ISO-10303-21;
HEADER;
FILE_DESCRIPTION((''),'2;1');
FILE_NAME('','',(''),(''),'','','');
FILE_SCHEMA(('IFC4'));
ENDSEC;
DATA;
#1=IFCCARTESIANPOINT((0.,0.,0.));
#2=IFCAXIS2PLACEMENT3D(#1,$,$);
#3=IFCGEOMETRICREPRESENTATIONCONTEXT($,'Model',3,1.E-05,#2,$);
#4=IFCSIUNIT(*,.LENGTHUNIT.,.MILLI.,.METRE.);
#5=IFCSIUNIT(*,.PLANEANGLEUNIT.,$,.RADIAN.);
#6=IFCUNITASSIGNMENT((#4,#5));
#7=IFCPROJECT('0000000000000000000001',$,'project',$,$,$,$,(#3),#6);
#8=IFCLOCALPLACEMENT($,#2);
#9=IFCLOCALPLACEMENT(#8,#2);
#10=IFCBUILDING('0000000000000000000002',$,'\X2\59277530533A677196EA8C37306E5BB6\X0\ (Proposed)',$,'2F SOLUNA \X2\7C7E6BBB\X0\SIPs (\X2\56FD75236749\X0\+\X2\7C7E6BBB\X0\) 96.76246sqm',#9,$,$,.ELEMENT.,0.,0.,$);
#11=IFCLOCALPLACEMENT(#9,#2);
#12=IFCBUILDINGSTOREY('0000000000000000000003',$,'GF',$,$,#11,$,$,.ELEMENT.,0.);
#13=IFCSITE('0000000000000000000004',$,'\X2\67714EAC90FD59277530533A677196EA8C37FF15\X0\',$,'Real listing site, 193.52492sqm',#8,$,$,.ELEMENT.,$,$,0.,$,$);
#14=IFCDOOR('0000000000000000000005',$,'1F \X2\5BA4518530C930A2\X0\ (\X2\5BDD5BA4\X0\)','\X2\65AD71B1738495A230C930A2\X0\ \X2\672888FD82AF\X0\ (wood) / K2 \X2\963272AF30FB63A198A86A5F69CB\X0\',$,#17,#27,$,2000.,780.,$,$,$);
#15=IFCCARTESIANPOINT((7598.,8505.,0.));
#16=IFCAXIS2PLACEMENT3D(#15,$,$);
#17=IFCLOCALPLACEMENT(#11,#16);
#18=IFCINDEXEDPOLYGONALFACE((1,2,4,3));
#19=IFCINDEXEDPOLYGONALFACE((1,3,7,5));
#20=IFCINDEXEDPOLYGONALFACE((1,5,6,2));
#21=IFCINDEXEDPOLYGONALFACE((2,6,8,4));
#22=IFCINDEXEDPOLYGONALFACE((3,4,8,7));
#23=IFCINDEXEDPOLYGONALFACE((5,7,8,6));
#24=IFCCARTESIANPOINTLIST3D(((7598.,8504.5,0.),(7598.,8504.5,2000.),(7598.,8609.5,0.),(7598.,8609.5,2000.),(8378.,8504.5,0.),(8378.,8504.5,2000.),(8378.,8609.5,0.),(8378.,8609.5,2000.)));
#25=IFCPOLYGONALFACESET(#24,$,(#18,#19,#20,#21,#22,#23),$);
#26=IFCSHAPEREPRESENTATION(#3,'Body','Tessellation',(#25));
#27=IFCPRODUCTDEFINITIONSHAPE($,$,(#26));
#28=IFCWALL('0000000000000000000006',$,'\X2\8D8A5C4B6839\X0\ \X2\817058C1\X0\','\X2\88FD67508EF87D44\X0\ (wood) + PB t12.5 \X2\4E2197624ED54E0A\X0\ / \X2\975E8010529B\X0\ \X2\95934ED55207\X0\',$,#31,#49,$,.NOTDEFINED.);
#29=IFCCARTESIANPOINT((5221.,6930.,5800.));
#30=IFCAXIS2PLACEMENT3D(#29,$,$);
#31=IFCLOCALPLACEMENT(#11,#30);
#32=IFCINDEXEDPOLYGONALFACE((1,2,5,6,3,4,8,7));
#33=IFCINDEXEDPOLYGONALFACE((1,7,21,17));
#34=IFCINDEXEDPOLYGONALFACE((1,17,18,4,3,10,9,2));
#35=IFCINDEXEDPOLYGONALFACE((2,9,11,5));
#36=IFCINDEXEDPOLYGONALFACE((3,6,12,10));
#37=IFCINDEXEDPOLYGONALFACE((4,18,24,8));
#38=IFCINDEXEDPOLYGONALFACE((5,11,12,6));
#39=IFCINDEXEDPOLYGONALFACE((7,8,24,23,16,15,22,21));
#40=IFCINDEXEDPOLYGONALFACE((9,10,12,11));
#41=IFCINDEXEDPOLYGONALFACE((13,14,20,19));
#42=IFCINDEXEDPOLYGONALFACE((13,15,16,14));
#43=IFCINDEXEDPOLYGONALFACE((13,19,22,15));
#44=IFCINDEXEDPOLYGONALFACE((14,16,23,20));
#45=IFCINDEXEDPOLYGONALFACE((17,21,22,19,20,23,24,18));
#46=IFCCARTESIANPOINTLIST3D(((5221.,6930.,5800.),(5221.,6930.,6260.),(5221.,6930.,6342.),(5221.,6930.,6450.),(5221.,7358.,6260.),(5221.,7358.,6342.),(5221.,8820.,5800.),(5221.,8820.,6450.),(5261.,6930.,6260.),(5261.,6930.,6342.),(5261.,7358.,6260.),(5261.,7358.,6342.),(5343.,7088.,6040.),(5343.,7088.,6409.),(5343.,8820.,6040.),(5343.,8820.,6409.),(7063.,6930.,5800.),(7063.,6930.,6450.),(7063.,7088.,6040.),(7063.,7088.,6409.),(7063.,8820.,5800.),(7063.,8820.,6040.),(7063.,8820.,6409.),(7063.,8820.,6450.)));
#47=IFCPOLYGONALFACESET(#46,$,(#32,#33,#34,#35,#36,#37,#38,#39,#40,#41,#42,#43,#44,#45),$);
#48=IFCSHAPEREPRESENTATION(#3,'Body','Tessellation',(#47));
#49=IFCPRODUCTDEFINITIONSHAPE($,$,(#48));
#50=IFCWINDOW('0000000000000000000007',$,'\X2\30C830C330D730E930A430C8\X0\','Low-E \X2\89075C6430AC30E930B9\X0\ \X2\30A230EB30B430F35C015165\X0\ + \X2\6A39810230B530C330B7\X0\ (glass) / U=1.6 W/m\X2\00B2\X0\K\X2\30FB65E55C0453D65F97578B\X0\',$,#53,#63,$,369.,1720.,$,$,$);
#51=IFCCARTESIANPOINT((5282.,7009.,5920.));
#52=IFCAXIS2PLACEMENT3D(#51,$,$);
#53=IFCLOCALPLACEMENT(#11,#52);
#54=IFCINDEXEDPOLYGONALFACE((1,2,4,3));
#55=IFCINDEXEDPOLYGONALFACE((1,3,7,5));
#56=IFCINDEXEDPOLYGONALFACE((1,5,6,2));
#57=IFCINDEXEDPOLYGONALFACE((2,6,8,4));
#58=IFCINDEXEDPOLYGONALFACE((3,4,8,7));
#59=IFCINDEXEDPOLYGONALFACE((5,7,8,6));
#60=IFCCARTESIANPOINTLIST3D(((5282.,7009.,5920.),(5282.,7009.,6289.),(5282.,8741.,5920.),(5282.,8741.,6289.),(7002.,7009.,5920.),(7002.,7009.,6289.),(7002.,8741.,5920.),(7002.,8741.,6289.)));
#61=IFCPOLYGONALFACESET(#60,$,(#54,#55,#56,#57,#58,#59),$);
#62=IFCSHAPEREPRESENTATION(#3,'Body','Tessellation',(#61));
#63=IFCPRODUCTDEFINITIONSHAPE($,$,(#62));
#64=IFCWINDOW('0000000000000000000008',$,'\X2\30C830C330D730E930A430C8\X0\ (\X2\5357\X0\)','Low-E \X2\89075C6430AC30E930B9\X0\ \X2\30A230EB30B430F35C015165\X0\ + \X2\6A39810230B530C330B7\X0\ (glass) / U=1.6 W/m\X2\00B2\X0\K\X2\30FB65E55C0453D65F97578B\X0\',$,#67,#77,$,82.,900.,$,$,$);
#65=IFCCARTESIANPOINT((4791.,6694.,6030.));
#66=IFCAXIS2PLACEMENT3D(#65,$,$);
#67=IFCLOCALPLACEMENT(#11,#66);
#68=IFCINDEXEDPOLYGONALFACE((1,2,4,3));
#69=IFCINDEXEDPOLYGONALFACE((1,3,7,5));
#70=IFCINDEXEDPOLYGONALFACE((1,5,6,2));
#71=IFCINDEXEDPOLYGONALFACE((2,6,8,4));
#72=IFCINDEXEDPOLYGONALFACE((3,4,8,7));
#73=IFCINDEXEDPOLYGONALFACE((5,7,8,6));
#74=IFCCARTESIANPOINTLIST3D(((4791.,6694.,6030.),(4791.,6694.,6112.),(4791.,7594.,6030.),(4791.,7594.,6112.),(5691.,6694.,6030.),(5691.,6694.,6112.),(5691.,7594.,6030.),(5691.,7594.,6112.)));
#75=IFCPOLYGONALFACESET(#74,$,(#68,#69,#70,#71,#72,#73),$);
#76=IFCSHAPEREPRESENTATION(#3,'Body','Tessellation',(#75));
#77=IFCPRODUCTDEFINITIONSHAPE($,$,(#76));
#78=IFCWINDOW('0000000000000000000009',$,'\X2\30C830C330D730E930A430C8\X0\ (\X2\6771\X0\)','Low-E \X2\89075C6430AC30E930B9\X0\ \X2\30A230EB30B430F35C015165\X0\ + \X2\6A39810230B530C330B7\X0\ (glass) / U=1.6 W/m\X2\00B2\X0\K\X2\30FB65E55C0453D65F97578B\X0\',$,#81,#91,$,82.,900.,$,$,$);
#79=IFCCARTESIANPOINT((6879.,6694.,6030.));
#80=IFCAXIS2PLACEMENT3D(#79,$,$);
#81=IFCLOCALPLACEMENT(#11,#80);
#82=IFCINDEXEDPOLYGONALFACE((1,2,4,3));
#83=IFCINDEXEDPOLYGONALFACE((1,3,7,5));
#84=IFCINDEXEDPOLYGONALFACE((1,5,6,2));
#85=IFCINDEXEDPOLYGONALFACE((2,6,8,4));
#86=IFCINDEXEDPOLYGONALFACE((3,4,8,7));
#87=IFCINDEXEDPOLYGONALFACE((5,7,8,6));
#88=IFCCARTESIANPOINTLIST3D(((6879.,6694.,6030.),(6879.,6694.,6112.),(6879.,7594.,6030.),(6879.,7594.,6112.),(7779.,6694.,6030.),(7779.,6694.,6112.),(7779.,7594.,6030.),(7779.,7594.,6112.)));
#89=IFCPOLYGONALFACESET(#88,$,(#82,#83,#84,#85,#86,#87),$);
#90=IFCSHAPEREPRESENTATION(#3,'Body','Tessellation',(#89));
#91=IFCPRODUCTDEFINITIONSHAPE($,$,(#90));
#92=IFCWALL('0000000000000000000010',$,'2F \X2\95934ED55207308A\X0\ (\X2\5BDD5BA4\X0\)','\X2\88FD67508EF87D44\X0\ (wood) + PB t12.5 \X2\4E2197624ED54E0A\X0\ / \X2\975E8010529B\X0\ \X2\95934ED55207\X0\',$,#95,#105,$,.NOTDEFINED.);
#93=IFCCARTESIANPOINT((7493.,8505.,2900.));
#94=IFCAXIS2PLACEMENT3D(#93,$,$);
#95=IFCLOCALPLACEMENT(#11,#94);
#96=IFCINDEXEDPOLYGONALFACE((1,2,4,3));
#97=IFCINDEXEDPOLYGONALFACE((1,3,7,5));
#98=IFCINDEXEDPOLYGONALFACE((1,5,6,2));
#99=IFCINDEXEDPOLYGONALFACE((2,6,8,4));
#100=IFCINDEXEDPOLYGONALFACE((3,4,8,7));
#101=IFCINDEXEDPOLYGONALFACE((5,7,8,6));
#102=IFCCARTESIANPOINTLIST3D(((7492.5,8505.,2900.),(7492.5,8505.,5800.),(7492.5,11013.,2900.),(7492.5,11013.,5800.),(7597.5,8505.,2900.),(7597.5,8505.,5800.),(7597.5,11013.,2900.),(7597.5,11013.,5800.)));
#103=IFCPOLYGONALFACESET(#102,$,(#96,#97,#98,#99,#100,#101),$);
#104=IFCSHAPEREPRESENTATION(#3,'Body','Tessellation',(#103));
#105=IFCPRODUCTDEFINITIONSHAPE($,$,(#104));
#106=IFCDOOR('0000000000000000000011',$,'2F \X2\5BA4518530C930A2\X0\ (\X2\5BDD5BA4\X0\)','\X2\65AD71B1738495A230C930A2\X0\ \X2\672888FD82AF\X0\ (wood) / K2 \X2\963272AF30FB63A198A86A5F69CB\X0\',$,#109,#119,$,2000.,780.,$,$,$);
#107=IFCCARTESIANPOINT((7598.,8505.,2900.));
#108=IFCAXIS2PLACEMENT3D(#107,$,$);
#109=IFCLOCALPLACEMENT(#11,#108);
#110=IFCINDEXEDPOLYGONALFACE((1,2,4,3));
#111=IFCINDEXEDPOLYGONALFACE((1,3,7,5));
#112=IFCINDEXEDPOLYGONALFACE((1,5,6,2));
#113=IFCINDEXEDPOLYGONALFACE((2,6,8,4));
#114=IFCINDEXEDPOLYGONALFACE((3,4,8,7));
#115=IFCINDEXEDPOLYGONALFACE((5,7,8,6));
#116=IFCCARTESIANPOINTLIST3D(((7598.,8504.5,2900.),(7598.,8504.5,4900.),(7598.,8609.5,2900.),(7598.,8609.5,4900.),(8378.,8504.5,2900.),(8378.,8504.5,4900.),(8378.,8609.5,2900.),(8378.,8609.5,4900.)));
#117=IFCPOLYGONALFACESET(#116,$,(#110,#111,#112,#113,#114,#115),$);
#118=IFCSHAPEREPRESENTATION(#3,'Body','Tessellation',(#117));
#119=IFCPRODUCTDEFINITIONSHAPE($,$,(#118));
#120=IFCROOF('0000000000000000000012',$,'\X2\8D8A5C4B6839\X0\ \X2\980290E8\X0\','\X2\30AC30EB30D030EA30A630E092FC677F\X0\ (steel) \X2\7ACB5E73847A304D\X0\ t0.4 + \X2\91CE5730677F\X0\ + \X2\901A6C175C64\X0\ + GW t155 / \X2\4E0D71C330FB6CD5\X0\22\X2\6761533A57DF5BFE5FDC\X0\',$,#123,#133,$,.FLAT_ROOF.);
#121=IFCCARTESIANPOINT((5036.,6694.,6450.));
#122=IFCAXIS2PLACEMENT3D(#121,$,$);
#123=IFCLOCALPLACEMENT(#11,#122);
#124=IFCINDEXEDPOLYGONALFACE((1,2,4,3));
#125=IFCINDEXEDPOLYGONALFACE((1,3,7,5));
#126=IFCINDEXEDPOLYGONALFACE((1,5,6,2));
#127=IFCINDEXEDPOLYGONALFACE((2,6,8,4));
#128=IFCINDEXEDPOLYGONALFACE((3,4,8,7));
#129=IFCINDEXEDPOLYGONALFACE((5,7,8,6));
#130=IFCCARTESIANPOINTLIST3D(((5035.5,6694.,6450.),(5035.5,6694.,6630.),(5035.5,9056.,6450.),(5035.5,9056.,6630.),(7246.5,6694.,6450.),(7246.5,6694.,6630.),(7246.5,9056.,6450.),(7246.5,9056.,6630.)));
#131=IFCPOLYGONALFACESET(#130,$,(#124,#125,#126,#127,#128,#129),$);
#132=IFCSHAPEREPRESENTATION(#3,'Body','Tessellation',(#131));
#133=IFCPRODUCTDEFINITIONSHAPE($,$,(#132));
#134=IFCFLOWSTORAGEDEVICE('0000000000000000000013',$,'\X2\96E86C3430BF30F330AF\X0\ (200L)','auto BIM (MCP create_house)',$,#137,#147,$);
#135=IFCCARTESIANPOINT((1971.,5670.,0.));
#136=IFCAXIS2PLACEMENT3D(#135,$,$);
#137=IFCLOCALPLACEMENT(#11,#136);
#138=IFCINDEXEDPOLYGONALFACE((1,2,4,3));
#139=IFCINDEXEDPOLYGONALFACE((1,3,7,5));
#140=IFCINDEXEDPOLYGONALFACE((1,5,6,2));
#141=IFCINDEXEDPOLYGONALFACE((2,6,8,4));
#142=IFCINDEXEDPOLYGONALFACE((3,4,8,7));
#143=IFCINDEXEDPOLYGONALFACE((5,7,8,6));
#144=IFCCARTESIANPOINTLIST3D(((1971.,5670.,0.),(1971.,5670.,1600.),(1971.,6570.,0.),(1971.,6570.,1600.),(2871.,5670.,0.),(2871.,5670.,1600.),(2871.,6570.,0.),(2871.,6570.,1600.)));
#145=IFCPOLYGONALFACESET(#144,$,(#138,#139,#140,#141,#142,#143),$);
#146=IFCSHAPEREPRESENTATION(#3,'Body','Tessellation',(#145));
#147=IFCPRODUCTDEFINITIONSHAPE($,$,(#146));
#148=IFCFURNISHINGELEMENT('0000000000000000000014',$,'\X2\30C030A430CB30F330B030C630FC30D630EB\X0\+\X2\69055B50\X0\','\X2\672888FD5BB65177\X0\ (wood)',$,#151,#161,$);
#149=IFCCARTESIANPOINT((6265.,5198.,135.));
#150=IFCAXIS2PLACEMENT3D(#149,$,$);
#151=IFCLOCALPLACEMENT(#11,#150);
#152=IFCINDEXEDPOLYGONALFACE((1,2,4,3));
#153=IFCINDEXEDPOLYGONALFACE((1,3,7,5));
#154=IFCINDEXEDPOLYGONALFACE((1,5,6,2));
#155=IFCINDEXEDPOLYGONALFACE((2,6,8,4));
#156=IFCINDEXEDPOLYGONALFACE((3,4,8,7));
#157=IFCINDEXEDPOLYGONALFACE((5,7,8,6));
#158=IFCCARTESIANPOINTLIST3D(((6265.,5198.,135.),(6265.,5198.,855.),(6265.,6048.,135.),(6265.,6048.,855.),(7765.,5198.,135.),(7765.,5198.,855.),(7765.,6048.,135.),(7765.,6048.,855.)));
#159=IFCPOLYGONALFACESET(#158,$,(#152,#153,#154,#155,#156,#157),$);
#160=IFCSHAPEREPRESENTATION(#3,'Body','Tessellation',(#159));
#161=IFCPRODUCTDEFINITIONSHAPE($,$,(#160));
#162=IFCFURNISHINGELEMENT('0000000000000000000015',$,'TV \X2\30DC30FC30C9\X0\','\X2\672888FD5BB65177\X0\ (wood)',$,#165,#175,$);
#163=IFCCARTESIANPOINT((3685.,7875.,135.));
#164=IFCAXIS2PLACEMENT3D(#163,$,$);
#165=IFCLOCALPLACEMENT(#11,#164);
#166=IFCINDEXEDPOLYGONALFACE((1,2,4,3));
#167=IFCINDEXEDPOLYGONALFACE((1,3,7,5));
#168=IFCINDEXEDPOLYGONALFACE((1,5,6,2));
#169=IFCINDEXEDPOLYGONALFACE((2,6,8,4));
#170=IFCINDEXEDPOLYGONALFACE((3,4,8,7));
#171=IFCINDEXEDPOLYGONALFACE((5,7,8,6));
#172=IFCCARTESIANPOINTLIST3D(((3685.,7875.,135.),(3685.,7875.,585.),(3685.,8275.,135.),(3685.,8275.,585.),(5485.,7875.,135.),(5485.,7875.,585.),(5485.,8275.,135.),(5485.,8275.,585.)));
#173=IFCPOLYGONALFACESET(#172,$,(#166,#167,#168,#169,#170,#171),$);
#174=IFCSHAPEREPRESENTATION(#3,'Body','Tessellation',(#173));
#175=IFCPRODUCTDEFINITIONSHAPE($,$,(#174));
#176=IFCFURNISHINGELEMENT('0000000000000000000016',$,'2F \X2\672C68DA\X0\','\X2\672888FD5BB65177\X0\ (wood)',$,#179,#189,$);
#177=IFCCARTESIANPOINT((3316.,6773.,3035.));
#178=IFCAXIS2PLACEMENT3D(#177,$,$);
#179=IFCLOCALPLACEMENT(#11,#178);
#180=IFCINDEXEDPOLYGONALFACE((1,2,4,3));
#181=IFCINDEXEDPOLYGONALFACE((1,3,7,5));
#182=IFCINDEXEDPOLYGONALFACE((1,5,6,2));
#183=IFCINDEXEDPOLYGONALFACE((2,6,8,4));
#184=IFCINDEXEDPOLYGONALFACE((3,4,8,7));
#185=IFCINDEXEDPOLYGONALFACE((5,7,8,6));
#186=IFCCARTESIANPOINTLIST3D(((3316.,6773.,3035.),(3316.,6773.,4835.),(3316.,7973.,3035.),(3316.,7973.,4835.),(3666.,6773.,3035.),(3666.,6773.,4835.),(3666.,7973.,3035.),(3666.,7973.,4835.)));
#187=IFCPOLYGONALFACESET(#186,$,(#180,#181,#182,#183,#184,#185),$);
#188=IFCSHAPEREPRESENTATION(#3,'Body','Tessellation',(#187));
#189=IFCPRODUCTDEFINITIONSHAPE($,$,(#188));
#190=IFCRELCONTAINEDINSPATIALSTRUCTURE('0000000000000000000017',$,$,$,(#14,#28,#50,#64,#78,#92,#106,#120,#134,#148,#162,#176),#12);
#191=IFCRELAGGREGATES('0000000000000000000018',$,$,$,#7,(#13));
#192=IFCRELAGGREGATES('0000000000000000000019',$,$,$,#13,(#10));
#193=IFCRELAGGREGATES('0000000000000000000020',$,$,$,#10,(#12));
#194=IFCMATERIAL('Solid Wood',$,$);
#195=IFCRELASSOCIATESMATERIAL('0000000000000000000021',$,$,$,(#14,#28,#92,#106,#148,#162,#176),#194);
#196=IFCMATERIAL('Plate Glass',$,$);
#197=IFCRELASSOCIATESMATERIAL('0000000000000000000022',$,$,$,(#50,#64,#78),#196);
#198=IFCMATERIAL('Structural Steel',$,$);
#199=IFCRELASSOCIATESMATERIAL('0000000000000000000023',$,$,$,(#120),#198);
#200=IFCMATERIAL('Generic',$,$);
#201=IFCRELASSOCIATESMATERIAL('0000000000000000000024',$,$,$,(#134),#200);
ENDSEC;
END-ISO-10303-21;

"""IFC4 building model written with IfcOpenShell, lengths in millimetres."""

from ifc_helpers import new_model, si_unit, frame, frame_2d, origin, place, context, project, spatial, rectangle, extrude, material, element, fill, save


model = new_model("IFC4")

# Units and contexts
model_context = context("Model", 3, precision=1e-05, world=origin())
ifc_project = project(units=[si_unit("LENGTHUNIT", "METRE", prefix="MILLI"), si_unit("PLANEANGLEUNIT", "RADIAN")], contexts=[model_context])

# Site, building, storey
site_placement = place(None, origin())
site = spatial("IfcSite", under=ifc_project, at=site_placement, Name="東京都大田区東雪谷５", ObjectType="Real listing site, 193.52492sqm", CompositionType="ELEMENT", RefElevation=0.0)
building_placement = place(site_placement, origin())
building = spatial("IfcBuilding", under=site, at=building_placement, Name="大田区東雪谷の家 (Proposed)", ObjectType="2F SOLUNA 籾殻SIPs (国産杉+籾殻) 96.76246sqm", CompositionType="ELEMENT", ElevationOfRefHeight=0.0, ElevationOfTerrain=0.0)
storey_placement = place(building_placement, origin())
storey = spatial("IfcBuildingStorey", under=building, at=storey_placement, Name="GF", CompositionType="ELEMENT", Elevation=0.0)

# Shared definitions
ifc_material_1 = material(Name="Solid Wood")

# Door
door_1_placement = place(storey_placement, frame((7598.0, 8505.0, 0.0)))
element("IfcDoor", 1, at=door_1_placement, inside=storey, material=ifc_material_1, Name="1F 室内ドア (寝室)", Description="断熱玄関ドア 木製芯 (wood) / K2 防犯・採風機構", OverallHeight=2000.0, OverallWidth=780.0, context=model_context, shape_type="SweptSolid", body=[
    extrude(rectangle(XDim=780.0, YDim=105.0, at=frame_2d((390.0, 52.0))), frame((7598.0, 8505.0, 0.0)), (0.0, 0.0, 1.0), 2000.0),
])

# Wall, openings, windows
wall_1_placement = place(storey_placement, frame((5221.0, 6930.0, 5800.0)))
wall_1 = element("IfcWall", 2, at=wall_1_placement, inside=storey, material=ifc_material_1, Name="越屋根 腰壁", Description="製材軸組 (wood) + PB t12.5 両面仕上 / 非耐力 間仕切", PredefinedType="NOTDEFINED", context=model_context, shape_type="SweptSolid", body=[
    extrude(rectangle(XDim=1842.0, YDim=1890.0, at=frame_2d((921.0, 945.0))), frame((5221.0, 6930.0, 5800.0)), (0.0, 0.0, 1.0), 650.0),
])
opening_1_placement = place(storey_placement, frame((5282.0, 7009.0, 5920.0)))
opening_1 = element("IfcOpeningElement", 3, at=opening_1_placement, cuts=wall_1, PredefinedType="NOTDEFINED", context=model_context, shape_type="SweptSolid", body=[
    extrude(rectangle(XDim=1720.0, YDim=1732.0, at=frame_2d((860.0, 866.0))), frame((5282.0, 7009.0, 5920.0)), (0.0, 0.0, 1.0), 369.0),
])
opening_2_placement = place(storey_placement, frame((4791.0, 6694.0, 6030.0)))
opening_2 = element("IfcOpeningElement", 4, at=opening_2_placement, cuts=wall_1, PredefinedType="NOTDEFINED", context=model_context, shape_type="SweptSolid", body=[
    extrude(rectangle(XDim=900.0, YDim=900.0, at=frame_2d((450.0, 450.0))), frame((4791.0, 6694.0, 6030.0)), (0.0, 0.0, 1.0), 82.0),
])
opening_3_placement = place(storey_placement, frame((6879.0, 6694.0, 6030.0)))
opening_3 = element("IfcOpeningElement", 5, at=opening_3_placement, cuts=wall_1, PredefinedType="NOTDEFINED", context=model_context, shape_type="SweptSolid", body=[
    extrude(rectangle(XDim=900.0, YDim=900.0, at=frame_2d((450.0, 450.0))), frame((6879.0, 6694.0, 6030.0)), (0.0, 0.0, 1.0), 82.0),
])
ifc_material_2 = material(Name="Plate Glass")
window_1_placement = place(storey_placement, frame((5282.0, 7009.0, 5920.0)))
window_1 = element("IfcWindow", 6, at=window_1_placement, inside=storey, material=ifc_material_2, Name="トップライト", Description="Low-E 複層ガラス アルゴン封入 + 樹脂サッシ (glass) / U=1.6 W/m²K・日射取得型", OverallHeight=369.0, OverallWidth=1720.0, context=model_context, shape_type="SweptSolid", body=[
    extrude(rectangle(XDim=1720.0, YDim=1732.0, at=frame_2d((860.0, 866.0))), frame((5282.0, 7009.0, 5920.0)), (0.0, 0.0, 1.0), 369.0),
])
fill(opening_1, window_1)
window_2_placement = place(storey_placement, frame((4791.0, 6694.0, 6030.0)))
window_2 = element("IfcWindow", 7, at=window_2_placement, inside=storey, material=ifc_material_2, Name="トップライト (南)", Description="Low-E 複層ガラス アルゴン封入 + 樹脂サッシ (glass) / U=1.6 W/m²K・日射取得型", OverallHeight=82.0, OverallWidth=900.0, context=model_context, shape_type="SweptSolid", body=[
    extrude(rectangle(XDim=900.0, YDim=900.0, at=frame_2d((450.0, 450.0))), frame((4791.0, 6694.0, 6030.0)), (0.0, 0.0, 1.0), 82.0),
])
fill(opening_2, window_2)
window_3_placement = place(storey_placement, frame((6879.0, 6694.0, 6030.0)))
window_3 = element("IfcWindow", 8, at=window_3_placement, inside=storey, material=ifc_material_2, Name="トップライト (東)", Description="Low-E 複層ガラス アルゴン封入 + 樹脂サッシ (glass) / U=1.6 W/m²K・日射取得型", OverallHeight=82.0, OverallWidth=900.0, context=model_context, shape_type="SweptSolid", body=[
    extrude(rectangle(XDim=900.0, YDim=900.0, at=frame_2d((450.0, 450.0))), frame((6879.0, 6694.0, 6030.0)), (0.0, 0.0, 1.0), 82.0),
])
fill(opening_3, window_3)

# Wall
wall_2_placement = place(storey_placement, frame((7493.0, 8505.0, 2900.0)))
element("IfcWall", 9, at=wall_2_placement, inside=storey, material=ifc_material_1, Name="2F 間仕切り (寝室)", Description="製材軸組 (wood) + PB t12.5 両面仕上 / 非耐力 間仕切", PredefinedType="NOTDEFINED", context=model_context, shape_type="SweptSolid", body=[
    extrude(rectangle(XDim=105.0, YDim=2508.0, at=frame_2d((52.0, 1254.0))), frame((7493.0, 8505.0, 2900.0)), (0.0, 0.0, 1.0), 2900.0),
])

# Door
door_2_placement = place(storey_placement, frame((7598.0, 8505.0, 2900.0)))
element("IfcDoor", 10, at=door_2_placement, inside=storey, material=ifc_material_1, Name="2F 室内ドア (寝室)", Description="断熱玄関ドア 木製芯 (wood) / K2 防犯・採風機構", OverallHeight=2000.0, OverallWidth=780.0, context=model_context, shape_type="SweptSolid", body=[
    extrude(rectangle(XDim=780.0, YDim=105.0, at=frame_2d((390.0, 52.0))), frame((7598.0, 8505.0, 2900.0)), (0.0, 0.0, 1.0), 2000.0),
])

# Roof
ifc_material_3 = material(Name="Structural Steel")
roof_placement = place(storey_placement, frame((5036.0, 6694.0, 6450.0)))
element("IfcRoof", 11, at=roof_placement, inside=storey, material=ifc_material_3, Name="越屋根 頂部", Description="ガルバリウム鋼板 (steel) 立平葺き t0.4 + 野地板 + 通気層 + GW t155 / 不燃・法22条区域対応", PredefinedType="FLAT_ROOF", context=model_context, shape_type="SweptSolid", body=[
    extrude(rectangle(XDim=2211.0, YDim=2362.0, at=frame_2d((1105.0, 1181.0))), frame((5036.0, 6694.0, 6450.0)), (0.0, 0.0, 1.0), 180.0),
])

# Flow storage device
ifc_material_4 = material(Name="Generic")
flow_storage_device_placement = place(storey_placement, frame((1971.0, 5670.0, 0.0)))
element("IfcFlowStorageDevice", 12, at=flow_storage_device_placement, inside=storey, material=ifc_material_4, Name="雨水タンク (200L)", Description="auto BIM (MCP create_house)", context=model_context, shape_type="SweptSolid", body=[
    extrude(rectangle(XDim=900.0, YDim=900.0, at=frame_2d((450.0, 450.0))), frame((1971.0, 5670.0, 0.0)), (0.0, 0.0, 1.0), 1600.0),
])

# Furnishing elements
furnishing_1_placement = place(storey_placement, frame((6265.0, 5198.0, 135.0)))
element("IfcFurnishingElement", 13, at=furnishing_1_placement, inside=storey, material=ifc_material_1, Name="ダイニングテーブル+椅子", Description="木製家具 (wood)", context=model_context, shape_type="SweptSolid", body=[
    extrude(rectangle(XDim=1500.0, YDim=850.0, at=frame_2d((750.0, 425.0))), frame((6265.0, 5198.0, 135.0)), (0.0, 0.0, 1.0), 720.0),
])
furnishing_2_placement = place(storey_placement, frame((3685.0, 7875.0, 135.0)))
element("IfcFurnishingElement", 14, at=furnishing_2_placement, inside=storey, material=ifc_material_1, Name="TV ボード", Description="木製家具 (wood)", context=model_context, shape_type="SweptSolid", body=[
    extrude(rectangle(XDim=1800.0, YDim=400.0, at=frame_2d((900.0, 200.0))), frame((3685.0, 7875.0, 135.0)), (0.0, 0.0, 1.0), 450.0),
])
furnishing_3_placement = place(storey_placement, frame((3316.0, 6773.0, 3035.0)))
element("IfcFurnishingElement", 15, at=furnishing_3_placement, inside=storey, material=ifc_material_1, Name="2F 本棚", Description="木製家具 (wood)", context=model_context, shape_type="SweptSolid", body=[
    extrude(rectangle(XDim=350.0, YDim=1200.0, at=frame_2d((175.0, 600.0))), frame((3316.0, 6773.0, 3035.0)), (0.0, 0.0, 1.0), 1800.0),
])

save(model, "model.ifc")
